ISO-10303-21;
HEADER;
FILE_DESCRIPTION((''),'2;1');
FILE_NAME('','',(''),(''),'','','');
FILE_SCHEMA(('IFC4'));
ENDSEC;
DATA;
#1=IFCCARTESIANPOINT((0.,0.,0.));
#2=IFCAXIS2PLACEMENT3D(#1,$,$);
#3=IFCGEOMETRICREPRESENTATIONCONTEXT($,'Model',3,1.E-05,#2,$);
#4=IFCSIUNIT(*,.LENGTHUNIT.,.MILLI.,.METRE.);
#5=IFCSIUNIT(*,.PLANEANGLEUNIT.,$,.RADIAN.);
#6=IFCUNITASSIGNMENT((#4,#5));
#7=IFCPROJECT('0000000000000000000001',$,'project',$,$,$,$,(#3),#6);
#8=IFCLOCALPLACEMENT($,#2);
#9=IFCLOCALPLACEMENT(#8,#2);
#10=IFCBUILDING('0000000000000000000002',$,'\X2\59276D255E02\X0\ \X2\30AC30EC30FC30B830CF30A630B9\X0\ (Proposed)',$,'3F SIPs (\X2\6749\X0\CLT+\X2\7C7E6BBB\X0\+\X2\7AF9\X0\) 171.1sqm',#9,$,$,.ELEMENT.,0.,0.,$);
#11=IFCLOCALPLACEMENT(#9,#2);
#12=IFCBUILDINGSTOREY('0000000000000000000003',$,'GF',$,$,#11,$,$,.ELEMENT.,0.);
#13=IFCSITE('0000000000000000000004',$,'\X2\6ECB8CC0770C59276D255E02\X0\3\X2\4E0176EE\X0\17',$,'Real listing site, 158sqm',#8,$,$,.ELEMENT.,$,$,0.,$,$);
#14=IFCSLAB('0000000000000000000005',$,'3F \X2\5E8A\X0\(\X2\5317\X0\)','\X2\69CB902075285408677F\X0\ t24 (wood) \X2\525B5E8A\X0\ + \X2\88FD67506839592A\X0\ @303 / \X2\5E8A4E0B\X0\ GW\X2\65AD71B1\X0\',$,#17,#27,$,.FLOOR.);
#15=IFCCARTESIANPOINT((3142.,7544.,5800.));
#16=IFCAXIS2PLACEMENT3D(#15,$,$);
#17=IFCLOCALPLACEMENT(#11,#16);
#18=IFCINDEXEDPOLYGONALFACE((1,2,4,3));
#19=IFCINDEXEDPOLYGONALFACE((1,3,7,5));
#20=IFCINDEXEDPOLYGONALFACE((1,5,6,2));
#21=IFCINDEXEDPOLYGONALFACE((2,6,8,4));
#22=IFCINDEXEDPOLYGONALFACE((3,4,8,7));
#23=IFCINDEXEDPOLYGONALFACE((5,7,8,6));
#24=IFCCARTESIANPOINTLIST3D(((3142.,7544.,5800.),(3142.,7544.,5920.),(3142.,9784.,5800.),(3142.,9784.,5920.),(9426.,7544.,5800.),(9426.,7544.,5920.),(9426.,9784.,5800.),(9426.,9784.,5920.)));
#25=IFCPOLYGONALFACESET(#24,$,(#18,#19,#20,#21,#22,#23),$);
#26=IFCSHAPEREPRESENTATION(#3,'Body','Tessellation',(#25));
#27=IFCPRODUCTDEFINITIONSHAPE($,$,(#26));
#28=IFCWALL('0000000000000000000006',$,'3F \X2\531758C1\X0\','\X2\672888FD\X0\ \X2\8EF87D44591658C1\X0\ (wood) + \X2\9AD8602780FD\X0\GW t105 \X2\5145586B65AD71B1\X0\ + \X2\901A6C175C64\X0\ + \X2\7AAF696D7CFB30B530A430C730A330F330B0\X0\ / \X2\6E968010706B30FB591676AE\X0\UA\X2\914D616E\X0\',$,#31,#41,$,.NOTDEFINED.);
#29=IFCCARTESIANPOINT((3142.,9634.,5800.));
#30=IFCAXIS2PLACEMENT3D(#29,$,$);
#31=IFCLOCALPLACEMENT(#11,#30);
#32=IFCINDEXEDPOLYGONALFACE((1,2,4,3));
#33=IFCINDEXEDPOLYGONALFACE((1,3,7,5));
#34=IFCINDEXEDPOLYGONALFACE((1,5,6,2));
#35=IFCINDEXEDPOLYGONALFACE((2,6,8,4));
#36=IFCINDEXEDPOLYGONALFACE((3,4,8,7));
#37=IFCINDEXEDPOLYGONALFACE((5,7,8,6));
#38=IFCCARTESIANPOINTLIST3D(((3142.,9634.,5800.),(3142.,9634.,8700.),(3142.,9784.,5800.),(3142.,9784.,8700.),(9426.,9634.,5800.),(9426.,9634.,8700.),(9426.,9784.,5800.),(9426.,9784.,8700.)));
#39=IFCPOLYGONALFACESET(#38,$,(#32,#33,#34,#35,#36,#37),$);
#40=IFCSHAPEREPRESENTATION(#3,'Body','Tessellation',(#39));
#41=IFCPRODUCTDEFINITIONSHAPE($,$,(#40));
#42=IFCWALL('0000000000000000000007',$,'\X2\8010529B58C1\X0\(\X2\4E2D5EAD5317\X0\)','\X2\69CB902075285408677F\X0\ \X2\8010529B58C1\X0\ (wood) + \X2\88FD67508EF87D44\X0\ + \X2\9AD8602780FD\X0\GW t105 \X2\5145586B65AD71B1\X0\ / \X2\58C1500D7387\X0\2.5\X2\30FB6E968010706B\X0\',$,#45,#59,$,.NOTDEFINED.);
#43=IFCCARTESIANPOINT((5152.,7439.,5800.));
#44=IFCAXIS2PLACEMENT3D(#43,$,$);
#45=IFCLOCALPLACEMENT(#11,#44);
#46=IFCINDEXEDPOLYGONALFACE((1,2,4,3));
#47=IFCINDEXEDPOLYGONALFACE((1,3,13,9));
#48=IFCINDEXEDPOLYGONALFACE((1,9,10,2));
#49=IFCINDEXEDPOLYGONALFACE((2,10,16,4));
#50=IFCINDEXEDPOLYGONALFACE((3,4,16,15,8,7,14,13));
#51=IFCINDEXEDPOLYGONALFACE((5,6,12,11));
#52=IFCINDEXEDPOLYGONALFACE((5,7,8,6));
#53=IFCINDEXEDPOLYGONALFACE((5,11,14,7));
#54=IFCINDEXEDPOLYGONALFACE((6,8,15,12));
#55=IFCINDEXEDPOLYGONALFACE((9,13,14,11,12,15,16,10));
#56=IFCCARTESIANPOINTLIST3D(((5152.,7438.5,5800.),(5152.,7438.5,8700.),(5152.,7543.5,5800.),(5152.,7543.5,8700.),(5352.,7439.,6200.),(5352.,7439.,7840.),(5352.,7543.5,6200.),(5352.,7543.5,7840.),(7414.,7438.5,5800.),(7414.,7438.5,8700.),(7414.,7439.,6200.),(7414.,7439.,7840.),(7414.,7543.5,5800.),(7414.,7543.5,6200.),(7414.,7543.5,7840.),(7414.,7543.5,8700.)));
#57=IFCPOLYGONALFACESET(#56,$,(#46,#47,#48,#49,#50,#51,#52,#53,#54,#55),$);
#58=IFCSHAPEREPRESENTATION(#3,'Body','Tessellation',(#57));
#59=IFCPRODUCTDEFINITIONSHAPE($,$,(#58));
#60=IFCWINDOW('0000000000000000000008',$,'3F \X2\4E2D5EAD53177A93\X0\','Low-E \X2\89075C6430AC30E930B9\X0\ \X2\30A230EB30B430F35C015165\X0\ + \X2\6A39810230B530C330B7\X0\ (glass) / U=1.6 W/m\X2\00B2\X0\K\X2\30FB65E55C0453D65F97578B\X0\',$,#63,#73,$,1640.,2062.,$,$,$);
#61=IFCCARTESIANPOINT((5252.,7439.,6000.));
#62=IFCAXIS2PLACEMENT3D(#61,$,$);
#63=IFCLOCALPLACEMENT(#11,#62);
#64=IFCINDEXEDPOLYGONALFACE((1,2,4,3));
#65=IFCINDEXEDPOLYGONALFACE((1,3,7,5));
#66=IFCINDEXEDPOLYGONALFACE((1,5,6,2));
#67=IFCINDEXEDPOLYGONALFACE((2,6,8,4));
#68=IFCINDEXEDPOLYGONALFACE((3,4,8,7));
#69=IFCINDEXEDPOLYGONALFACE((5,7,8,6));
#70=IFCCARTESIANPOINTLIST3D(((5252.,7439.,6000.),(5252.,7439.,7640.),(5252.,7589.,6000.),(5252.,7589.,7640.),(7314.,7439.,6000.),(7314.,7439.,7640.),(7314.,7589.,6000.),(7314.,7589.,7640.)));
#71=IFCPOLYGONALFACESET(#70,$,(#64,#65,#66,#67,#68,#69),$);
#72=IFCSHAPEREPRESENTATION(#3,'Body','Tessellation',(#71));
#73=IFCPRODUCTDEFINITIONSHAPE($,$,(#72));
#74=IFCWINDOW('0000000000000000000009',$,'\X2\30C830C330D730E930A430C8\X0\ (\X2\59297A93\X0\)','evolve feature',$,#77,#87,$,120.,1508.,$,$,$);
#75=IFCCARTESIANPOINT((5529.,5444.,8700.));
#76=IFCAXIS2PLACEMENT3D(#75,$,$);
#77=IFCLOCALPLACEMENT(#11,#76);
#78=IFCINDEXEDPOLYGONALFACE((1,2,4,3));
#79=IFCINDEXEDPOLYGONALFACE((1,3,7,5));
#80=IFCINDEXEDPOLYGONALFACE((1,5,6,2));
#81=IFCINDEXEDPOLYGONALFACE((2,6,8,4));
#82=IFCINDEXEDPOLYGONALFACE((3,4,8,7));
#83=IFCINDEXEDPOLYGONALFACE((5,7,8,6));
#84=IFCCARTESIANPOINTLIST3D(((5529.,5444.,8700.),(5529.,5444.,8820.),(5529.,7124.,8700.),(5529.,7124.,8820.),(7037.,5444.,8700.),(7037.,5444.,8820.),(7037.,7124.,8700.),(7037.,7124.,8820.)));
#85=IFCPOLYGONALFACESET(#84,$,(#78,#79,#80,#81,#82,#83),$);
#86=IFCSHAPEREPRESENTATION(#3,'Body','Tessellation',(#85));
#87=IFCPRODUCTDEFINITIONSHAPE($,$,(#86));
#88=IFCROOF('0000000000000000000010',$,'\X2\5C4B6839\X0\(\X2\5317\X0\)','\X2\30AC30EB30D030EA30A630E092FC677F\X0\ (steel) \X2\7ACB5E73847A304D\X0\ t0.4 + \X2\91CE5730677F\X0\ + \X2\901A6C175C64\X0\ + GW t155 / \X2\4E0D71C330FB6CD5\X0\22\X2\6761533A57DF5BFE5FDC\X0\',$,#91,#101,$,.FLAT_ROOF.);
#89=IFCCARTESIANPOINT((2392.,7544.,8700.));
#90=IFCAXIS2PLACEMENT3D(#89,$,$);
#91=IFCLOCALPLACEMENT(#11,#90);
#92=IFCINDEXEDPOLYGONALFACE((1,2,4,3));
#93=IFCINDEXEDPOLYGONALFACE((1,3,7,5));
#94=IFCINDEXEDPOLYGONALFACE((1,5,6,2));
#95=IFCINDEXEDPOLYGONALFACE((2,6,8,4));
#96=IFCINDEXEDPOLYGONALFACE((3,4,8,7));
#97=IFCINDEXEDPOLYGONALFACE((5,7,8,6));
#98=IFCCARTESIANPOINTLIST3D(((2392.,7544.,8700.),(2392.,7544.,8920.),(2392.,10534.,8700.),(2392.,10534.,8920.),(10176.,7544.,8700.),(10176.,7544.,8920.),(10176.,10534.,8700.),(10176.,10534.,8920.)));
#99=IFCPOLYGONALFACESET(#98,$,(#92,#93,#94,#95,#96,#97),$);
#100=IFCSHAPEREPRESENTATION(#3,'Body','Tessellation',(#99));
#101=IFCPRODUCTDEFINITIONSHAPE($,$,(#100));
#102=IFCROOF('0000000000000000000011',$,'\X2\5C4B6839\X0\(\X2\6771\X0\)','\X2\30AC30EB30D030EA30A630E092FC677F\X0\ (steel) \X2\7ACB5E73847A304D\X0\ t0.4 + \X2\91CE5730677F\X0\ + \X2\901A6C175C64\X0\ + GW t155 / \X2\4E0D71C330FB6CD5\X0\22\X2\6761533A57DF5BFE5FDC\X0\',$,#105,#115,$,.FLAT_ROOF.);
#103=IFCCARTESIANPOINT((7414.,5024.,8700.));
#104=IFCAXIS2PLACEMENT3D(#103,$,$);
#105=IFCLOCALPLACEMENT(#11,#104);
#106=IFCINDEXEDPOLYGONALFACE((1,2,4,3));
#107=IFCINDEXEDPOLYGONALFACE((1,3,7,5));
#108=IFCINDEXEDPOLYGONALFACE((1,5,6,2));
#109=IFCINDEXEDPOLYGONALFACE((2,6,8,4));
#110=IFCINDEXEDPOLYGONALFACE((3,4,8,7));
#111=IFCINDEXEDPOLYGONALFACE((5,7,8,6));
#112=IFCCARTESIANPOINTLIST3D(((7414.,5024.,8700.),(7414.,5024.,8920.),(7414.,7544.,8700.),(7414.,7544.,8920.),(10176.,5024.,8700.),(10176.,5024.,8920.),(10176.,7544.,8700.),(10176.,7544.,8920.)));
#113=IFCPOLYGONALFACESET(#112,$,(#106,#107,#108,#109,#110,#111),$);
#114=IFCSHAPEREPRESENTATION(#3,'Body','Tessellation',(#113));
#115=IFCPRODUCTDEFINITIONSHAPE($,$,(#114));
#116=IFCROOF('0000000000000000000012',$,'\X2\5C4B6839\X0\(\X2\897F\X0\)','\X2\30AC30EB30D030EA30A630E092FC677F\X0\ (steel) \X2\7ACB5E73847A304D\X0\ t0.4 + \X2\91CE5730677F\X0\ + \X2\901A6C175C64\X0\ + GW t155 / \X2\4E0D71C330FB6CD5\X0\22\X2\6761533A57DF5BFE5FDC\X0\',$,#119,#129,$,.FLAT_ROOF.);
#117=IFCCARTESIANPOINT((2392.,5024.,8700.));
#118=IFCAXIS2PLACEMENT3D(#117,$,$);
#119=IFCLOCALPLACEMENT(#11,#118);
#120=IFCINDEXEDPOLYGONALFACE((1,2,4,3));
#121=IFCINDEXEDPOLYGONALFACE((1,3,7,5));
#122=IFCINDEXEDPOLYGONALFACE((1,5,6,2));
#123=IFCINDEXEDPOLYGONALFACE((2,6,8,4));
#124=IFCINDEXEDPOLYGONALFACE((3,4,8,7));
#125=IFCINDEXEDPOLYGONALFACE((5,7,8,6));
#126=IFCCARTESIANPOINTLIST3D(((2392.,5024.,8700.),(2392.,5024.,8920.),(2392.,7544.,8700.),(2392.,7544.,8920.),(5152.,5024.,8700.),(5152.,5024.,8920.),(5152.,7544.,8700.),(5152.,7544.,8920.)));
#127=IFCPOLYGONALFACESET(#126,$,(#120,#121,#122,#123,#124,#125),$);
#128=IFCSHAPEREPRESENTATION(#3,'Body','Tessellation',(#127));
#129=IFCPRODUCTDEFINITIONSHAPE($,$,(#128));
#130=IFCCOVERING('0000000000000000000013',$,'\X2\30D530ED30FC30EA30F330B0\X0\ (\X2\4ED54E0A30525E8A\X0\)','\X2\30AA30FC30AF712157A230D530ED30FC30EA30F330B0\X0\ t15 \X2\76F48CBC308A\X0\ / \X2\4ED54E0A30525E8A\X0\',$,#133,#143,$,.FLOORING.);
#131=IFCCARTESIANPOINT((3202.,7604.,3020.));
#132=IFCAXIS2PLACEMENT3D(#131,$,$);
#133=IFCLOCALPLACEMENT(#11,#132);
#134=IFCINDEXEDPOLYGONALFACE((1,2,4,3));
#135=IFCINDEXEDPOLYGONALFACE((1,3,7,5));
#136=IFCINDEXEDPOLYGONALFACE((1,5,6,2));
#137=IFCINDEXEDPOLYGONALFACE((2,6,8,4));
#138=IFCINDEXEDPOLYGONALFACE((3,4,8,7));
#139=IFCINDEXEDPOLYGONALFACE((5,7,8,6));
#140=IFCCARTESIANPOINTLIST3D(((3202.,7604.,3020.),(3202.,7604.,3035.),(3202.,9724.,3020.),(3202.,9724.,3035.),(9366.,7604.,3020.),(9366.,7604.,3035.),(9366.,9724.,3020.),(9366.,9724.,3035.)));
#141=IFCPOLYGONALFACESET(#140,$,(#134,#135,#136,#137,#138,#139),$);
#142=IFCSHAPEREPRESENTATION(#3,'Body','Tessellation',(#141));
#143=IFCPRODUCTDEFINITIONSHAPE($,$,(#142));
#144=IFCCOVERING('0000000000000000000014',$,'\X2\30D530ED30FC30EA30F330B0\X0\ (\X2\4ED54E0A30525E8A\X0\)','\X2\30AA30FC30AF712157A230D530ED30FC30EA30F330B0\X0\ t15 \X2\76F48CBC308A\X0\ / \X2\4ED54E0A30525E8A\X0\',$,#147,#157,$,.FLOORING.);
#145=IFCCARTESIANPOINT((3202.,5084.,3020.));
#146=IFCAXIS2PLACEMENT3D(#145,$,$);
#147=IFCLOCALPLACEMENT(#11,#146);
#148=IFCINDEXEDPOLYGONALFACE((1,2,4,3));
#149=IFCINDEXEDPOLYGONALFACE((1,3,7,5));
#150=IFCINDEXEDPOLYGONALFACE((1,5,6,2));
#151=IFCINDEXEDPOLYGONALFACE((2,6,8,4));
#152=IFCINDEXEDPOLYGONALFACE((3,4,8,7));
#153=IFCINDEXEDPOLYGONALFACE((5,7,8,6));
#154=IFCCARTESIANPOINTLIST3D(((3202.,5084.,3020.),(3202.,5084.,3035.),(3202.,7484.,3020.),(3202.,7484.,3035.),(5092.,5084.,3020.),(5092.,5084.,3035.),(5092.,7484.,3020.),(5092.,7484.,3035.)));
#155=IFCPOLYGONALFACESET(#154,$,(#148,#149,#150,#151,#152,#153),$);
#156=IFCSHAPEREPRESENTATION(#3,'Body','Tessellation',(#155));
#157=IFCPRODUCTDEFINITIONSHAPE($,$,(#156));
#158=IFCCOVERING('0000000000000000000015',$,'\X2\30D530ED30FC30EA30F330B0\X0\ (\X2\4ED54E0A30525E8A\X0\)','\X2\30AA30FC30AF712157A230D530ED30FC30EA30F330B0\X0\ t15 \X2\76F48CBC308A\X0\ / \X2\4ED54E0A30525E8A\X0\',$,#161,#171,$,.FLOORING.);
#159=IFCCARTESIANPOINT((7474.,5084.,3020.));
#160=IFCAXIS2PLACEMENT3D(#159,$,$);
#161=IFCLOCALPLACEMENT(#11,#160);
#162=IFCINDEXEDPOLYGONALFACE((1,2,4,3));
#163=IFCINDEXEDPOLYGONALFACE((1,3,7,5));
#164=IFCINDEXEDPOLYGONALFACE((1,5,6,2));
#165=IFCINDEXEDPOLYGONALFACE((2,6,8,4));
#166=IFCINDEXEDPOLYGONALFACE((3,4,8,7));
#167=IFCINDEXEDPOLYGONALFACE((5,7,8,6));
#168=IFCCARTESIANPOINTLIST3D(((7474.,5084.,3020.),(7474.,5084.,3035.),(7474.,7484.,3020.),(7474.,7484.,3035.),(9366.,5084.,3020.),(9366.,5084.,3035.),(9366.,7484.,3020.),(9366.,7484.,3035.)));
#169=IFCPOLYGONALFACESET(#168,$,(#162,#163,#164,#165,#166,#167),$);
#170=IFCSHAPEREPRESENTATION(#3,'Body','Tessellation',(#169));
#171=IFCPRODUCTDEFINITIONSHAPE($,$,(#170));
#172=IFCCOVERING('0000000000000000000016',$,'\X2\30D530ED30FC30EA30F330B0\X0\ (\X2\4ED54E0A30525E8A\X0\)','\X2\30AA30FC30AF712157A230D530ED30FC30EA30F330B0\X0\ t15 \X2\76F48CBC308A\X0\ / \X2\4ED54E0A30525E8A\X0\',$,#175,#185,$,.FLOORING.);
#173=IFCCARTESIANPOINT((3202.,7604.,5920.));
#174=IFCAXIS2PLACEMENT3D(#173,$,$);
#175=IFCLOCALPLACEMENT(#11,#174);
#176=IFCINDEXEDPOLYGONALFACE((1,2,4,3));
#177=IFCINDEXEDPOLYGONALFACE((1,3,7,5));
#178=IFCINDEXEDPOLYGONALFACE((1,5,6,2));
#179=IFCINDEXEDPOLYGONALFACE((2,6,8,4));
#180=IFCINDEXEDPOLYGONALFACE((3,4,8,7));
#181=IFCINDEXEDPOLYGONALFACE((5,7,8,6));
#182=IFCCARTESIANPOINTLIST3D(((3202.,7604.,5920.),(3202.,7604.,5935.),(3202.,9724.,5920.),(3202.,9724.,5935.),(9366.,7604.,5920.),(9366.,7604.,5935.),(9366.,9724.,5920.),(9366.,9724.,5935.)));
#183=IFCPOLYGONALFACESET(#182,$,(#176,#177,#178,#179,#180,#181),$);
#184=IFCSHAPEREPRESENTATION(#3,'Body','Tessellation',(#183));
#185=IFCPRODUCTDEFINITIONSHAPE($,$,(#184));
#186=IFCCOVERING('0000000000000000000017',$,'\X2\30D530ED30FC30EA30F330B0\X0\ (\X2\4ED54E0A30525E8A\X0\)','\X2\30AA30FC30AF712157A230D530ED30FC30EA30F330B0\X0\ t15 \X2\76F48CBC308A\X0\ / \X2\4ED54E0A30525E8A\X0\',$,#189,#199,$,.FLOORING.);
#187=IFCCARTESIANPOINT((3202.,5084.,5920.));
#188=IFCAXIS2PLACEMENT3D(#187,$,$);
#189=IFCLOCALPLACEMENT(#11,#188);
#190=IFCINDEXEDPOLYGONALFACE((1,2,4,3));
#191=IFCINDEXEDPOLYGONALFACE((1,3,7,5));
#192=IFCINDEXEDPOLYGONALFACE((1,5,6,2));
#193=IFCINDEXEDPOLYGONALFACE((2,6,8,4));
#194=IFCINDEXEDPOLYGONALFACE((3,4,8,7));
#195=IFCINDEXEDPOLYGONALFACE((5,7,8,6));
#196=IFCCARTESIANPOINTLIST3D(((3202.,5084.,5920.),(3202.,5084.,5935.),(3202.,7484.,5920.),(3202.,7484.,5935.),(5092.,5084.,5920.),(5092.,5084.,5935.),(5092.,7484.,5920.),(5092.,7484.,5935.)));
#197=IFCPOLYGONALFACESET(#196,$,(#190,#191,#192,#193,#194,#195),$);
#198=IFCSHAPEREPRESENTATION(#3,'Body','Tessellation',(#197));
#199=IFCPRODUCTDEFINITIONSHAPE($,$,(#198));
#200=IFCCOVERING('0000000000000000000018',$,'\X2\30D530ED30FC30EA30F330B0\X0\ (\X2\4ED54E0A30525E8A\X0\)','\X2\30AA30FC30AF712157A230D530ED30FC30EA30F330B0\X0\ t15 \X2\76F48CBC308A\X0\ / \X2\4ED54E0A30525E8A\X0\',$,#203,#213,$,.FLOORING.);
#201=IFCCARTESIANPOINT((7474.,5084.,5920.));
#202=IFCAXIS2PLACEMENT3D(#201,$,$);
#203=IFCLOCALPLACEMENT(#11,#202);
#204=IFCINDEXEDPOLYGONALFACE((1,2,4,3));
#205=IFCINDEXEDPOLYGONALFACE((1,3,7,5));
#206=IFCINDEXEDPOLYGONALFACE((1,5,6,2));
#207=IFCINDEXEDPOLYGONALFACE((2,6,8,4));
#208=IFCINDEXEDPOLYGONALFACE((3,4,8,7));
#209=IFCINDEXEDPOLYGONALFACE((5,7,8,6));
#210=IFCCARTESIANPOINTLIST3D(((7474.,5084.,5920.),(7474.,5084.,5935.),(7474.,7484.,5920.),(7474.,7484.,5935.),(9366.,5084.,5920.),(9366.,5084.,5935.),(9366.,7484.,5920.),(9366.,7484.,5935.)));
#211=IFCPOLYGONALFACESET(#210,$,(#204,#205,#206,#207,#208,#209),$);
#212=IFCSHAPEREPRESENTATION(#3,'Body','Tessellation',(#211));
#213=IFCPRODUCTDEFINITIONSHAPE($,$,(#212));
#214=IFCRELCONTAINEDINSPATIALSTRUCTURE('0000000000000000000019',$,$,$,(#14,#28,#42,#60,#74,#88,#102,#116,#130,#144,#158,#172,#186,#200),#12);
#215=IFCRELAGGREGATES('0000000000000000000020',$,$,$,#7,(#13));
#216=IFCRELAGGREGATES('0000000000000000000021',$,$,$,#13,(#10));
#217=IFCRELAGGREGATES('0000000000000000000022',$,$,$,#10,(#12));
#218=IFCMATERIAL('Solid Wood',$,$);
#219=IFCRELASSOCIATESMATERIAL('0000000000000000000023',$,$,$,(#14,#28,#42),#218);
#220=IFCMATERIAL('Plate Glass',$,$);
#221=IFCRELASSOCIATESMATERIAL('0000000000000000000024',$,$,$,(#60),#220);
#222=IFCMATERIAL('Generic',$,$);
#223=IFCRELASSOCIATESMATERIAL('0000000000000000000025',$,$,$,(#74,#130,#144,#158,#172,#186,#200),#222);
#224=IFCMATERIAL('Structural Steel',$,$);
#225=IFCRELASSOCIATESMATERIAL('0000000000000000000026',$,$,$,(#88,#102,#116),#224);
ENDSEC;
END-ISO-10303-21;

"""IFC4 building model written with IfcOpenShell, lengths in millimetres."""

from ifc_helpers import new_model, si_unit, frame, frame_2d, origin, place, context, project, spatial, rectangle, extrude, material, element, fill, save


model = new_model("IFC4")

# Units and contexts
model_context = context("Model", 3, precision=1e-05, world=origin())
ifc_project = project(units=[si_unit("LENGTHUNIT", "METRE", prefix="MILLI"), si_unit("PLANEANGLEUNIT", "RADIAN")], contexts=[model_context])

# Site, building, storey
site_placement = place(None, origin())
site = spatial("IfcSite", under=ifc_project, at=site_placement, Name="滋賀県大津市3丁目17", ObjectType="Real listing site, 158sqm", CompositionType="ELEMENT", RefElevation=0.0)
building_placement = place(site_placement, origin())
building = spatial("IfcBuilding", under=site, at=building_placement, Name="大津市 ガレージハウス (Proposed)", ObjectType="3F SIPs (杉CLT+籾殻+竹) 171.1sqm", CompositionType="ELEMENT", ElevationOfRefHeight=0.0, ElevationOfTerrain=0.0)
storey_placement = place(building_placement, origin())
storey = spatial("IfcBuildingStorey", under=building, at=storey_placement, Name="GF", CompositionType="ELEMENT", Elevation=0.0)

# Slab
ifc_material_1 = material(Name="Solid Wood")
slab_placement = place(storey_placement, frame((3142.0, 7544.0, 5800.0)))
element("IfcSlab", 1, at=slab_placement, inside=storey, material=ifc_material_1, Name="3F 床(北)", Description="構造用合板 t24 (wood) 剛床 + 製材根太 @303 / 床下 GW断熱", PredefinedType="FLOOR", context=model_context, shape_type="SweptSolid", body=[
    extrude(rectangle(XDim=6284.0, YDim=2240.0, at=frame_2d((3142.0, 1120.0))), frame((3142.0, 7544.0, 5800.0)), (0.0, 0.0, 1.0), 120.0),
])

# Wall
wall_1_placement = place(storey_placement, frame((3142.0, 9634.0, 5800.0)))
element("IfcWall", 2, at=wall_1_placement, inside=storey, material=ifc_material_1, Name="3F 北壁", Description="木製 軸組外壁 (wood) + 高性能GW t105 充填断熱 + 通気層 + 窯業系サイディング / 準耐火・外皮UA配慮", PredefinedType="NOTDEFINED", context=model_context, shape_type="SweptSolid", body=[
    extrude(rectangle(XDim=6284.0, YDim=150.0, at=frame_2d((3142.0, 75.0))), frame((3142.0, 9634.0, 5800.0)), (0.0, 0.0, 1.0), 2900.0),
])

# Wall, opening, window
wall_2_placement = place(storey_placement, frame((5152.0, 7439.0, 5800.0)))
wall_2 = element("IfcWall", 3, at=wall_2_placement, inside=storey, material=ifc_material_1, Name="耐力壁(中庭北)", Description="構造用合板 耐力壁 (wood) + 製材軸組 + 高性能GW t105 充填断熱 / 壁倍率2.5・準耐火", PredefinedType="NOTDEFINED", context=model_context, shape_type="SweptSolid", body=[
    extrude(rectangle(XDim=2262.0, YDim=105.0, at=frame_2d((1131.0, 52.0))), frame((5152.0, 7439.0, 5800.0)), (0.0, 0.0, 1.0), 2900.0),
])
opening_placement = place(storey_placement, frame((5252.0, 7439.0, 6000.0)))
opening = element("IfcOpeningElement", 4, at=opening_placement, cuts=wall_2, PredefinedType="NOTDEFINED", context=model_context, shape_type="SweptSolid", body=[
    extrude(rectangle(XDim=2062.0, YDim=150.0, at=frame_2d((1031.0, 75.0))), frame((5252.0, 7439.0, 6000.0)), (0.0, 0.0, 1.0), 1640.0),
])
ifc_material_2 = material(Name="Plate Glass")
window_1_placement = place(storey_placement, frame((5252.0, 7439.0, 6000.0)))
window_1 = element("IfcWindow", 5, at=window_1_placement, inside=storey, material=ifc_material_2, Name="3F 中庭北窓", Description="Low-E 複層ガラス アルゴン封入 + 樹脂サッシ (glass) / U=1.6 W/m²K・日射取得型", OverallHeight=1640.0, OverallWidth=2062.0, context=model_context, shape_type="SweptSolid", body=[
    extrude(rectangle(XDim=2062.0, YDim=150.0, at=frame_2d((1031.0, 75.0))), frame((5252.0, 7439.0, 6000.0)), (0.0, 0.0, 1.0), 1640.0),
])
fill(opening, window_1)

# Window
ifc_material_3 = material(Name="Generic")
window_2_placement = place(storey_placement, frame((5529.0, 5444.0, 8700.0)))
element("IfcWindow", 6, at=window_2_placement, inside=storey, material=ifc_material_3, Name="トップライト (天窓)", Description="evolve feature", OverallHeight=120.0, OverallWidth=1508.0, context=model_context, shape_type="SweptSolid", body=[
    extrude(rectangle(XDim=1508.0, YDim=1680.0, at=frame_2d((754.0, 840.0))), frame((5529.0, 5444.0, 8700.0)), (0.0, 0.0, 1.0), 120.0),
])

# Roofs
ifc_material_4 = material(Name="Structural Steel")
roof_1_placement = place(storey_placement, frame((2392.0, 7544.0, 8700.0)))
element("IfcRoof", 7, at=roof_1_placement, inside=storey, material=ifc_material_4, Name="屋根(北)", Description="ガルバリウム鋼板 (steel) 立平葺き t0.4 + 野地板 + 通気層 + GW t155 / 不燃・法22条区域対応", PredefinedType="FLAT_ROOF", context=model_context, shape_type="SweptSolid", body=[
    extrude(rectangle(XDim=7784.0, YDim=2990.0, at=frame_2d((3892.0, 1495.0))), frame((2392.0, 7544.0, 8700.0)), (0.0, 0.0, 1.0), 220.0),
])
roof_2_placement = place(storey_placement, frame((7414.0, 5024.0, 8700.0)))
element("IfcRoof", 8, at=roof_2_placement, inside=storey, material=ifc_material_4, Name="屋根(東)", Description="ガルバリウム鋼板 (steel) 立平葺き t0.4 + 野地板 + 通気層 + GW t155 / 不燃・法22条区域対応", PredefinedType="FLAT_ROOF", context=model_context, shape_type="SweptSolid", body=[
    extrude(rectangle(XDim=2762.0, YDim=2520.0, at=frame_2d((1381.0, 1260.0))), frame((7414.0, 5024.0, 8700.0)), (0.0, 0.0, 1.0), 220.0),
])
roof_3_placement = place(storey_placement, frame((2392.0, 5024.0, 8700.0)))
element("IfcRoof", 9, at=roof_3_placement, inside=storey, material=ifc_material_4, Name="屋根(西)", Description="ガルバリウム鋼板 (steel) 立平葺き t0.4 + 野地板 + 通気層 + GW t155 / 不燃・法22条区域対応", PredefinedType="FLAT_ROOF", context=model_context, shape_type="SweptSolid", body=[
    extrude(rectangle(XDim=2760.0, YDim=2520.0, at=frame_2d((1380.0, 1260.0))), frame((2392.0, 5024.0, 8700.0)), (0.0, 0.0, 1.0), 220.0),
])

# Coverings
covering_1_placement = place(storey_placement, frame((3202.0, 7604.0, 3020.0)))
element("IfcCovering", 10, at=covering_1_placement, inside=storey, material=ifc_material_3, Name="フローリング (仕上げ床)", Description="オーク無垢フローリング t15 直貼り / 仕上げ床", PredefinedType="FLOORING", context=model_context, shape_type="SweptSolid", body=[
    extrude(rectangle(XDim=6164.0, YDim=2120.0, at=frame_2d((3082.0, 1060.0))), frame((3202.0, 7604.0, 3020.0)), (0.0, 0.0, 1.0), 15.0),
])
covering_2_placement = place(storey_placement, frame((3202.0, 5084.0, 3020.0)))
element("IfcCovering", 11, at=covering_2_placement, inside=storey, material=ifc_material_3, Name="フローリング (仕上げ床)", Description="オーク無垢フローリング t15 直貼り / 仕上げ床", PredefinedType="FLOORING", context=model_context, shape_type="SweptSolid", body=[
    extrude(rectangle(XDim=1890.0, YDim=2400.0, at=frame_2d((945.0, 1200.0))), frame((3202.0, 5084.0, 3020.0)), (0.0, 0.0, 1.0), 15.0),
])
covering_3_placement = place(storey_placement, frame((7474.0, 5084.0, 3020.0)))
element("IfcCovering", 12, at=covering_3_placement, inside=storey, material=ifc_material_3, Name="フローリング (仕上げ床)", Description="オーク無垢フローリング t15 直貼り / 仕上げ床", PredefinedType="FLOORING", context=model_context, shape_type="SweptSolid", body=[
    extrude(rectangle(XDim=1892.0, YDim=2400.0, at=frame_2d((946.0, 1200.0))), frame((7474.0, 5084.0, 3020.0)), (0.0, 0.0, 1.0), 15.0),
])
covering_4_placement = place(storey_placement, frame((3202.0, 7604.0, 5920.0)))
element("IfcCovering", 13, at=covering_4_placement, inside=storey, material=ifc_material_3, Name="フローリング (仕上げ床)", Description="オーク無垢フローリング t15 直貼り / 仕上げ床", PredefinedType="FLOORING", context=model_context, shape_type="SweptSolid", body=[
    extrude(rectangle(XDim=6164.0, YDim=2120.0, at=frame_2d((3082.0, 1060.0))), frame((3202.0, 7604.0, 5920.0)), (0.0, 0.0, 1.0), 15.0),
])
covering_5_placement = place(storey_placement, frame((3202.0, 5084.0, 5920.0)))
element("IfcCovering", 14, at=covering_5_placement, inside=storey, material=ifc_material_3, Name="フローリング (仕上げ床)", Description="オーク無垢フローリング t15 直貼り / 仕上げ床", PredefinedType="FLOORING", context=model_context, shape_type="SweptSolid", body=[
    extrude(rectangle(XDim=1890.0, YDim=2400.0, at=frame_2d((945.0, 1200.0))), frame((3202.0, 5084.0, 5920.0)), (0.0, 0.0, 1.0), 15.0),
])
covering_6_placement = place(storey_placement, frame((7474.0, 5084.0, 5920.0)))
element("IfcCovering", 15, at=covering_6_placement, inside=storey, material=ifc_material_3, Name="フローリング (仕上げ床)", Description="オーク無垢フローリング t15 直貼り / 仕上げ床", PredefinedType="FLOORING", context=model_context, shape_type="SweptSolid", body=[
    extrude(rectangle(XDim=1892.0, YDim=2400.0, at=frame_2d((946.0, 1200.0))), frame((7474.0, 5084.0, 5920.0)), (0.0, 0.0, 1.0), 15.0),
])

save(model, "model.ifc")
